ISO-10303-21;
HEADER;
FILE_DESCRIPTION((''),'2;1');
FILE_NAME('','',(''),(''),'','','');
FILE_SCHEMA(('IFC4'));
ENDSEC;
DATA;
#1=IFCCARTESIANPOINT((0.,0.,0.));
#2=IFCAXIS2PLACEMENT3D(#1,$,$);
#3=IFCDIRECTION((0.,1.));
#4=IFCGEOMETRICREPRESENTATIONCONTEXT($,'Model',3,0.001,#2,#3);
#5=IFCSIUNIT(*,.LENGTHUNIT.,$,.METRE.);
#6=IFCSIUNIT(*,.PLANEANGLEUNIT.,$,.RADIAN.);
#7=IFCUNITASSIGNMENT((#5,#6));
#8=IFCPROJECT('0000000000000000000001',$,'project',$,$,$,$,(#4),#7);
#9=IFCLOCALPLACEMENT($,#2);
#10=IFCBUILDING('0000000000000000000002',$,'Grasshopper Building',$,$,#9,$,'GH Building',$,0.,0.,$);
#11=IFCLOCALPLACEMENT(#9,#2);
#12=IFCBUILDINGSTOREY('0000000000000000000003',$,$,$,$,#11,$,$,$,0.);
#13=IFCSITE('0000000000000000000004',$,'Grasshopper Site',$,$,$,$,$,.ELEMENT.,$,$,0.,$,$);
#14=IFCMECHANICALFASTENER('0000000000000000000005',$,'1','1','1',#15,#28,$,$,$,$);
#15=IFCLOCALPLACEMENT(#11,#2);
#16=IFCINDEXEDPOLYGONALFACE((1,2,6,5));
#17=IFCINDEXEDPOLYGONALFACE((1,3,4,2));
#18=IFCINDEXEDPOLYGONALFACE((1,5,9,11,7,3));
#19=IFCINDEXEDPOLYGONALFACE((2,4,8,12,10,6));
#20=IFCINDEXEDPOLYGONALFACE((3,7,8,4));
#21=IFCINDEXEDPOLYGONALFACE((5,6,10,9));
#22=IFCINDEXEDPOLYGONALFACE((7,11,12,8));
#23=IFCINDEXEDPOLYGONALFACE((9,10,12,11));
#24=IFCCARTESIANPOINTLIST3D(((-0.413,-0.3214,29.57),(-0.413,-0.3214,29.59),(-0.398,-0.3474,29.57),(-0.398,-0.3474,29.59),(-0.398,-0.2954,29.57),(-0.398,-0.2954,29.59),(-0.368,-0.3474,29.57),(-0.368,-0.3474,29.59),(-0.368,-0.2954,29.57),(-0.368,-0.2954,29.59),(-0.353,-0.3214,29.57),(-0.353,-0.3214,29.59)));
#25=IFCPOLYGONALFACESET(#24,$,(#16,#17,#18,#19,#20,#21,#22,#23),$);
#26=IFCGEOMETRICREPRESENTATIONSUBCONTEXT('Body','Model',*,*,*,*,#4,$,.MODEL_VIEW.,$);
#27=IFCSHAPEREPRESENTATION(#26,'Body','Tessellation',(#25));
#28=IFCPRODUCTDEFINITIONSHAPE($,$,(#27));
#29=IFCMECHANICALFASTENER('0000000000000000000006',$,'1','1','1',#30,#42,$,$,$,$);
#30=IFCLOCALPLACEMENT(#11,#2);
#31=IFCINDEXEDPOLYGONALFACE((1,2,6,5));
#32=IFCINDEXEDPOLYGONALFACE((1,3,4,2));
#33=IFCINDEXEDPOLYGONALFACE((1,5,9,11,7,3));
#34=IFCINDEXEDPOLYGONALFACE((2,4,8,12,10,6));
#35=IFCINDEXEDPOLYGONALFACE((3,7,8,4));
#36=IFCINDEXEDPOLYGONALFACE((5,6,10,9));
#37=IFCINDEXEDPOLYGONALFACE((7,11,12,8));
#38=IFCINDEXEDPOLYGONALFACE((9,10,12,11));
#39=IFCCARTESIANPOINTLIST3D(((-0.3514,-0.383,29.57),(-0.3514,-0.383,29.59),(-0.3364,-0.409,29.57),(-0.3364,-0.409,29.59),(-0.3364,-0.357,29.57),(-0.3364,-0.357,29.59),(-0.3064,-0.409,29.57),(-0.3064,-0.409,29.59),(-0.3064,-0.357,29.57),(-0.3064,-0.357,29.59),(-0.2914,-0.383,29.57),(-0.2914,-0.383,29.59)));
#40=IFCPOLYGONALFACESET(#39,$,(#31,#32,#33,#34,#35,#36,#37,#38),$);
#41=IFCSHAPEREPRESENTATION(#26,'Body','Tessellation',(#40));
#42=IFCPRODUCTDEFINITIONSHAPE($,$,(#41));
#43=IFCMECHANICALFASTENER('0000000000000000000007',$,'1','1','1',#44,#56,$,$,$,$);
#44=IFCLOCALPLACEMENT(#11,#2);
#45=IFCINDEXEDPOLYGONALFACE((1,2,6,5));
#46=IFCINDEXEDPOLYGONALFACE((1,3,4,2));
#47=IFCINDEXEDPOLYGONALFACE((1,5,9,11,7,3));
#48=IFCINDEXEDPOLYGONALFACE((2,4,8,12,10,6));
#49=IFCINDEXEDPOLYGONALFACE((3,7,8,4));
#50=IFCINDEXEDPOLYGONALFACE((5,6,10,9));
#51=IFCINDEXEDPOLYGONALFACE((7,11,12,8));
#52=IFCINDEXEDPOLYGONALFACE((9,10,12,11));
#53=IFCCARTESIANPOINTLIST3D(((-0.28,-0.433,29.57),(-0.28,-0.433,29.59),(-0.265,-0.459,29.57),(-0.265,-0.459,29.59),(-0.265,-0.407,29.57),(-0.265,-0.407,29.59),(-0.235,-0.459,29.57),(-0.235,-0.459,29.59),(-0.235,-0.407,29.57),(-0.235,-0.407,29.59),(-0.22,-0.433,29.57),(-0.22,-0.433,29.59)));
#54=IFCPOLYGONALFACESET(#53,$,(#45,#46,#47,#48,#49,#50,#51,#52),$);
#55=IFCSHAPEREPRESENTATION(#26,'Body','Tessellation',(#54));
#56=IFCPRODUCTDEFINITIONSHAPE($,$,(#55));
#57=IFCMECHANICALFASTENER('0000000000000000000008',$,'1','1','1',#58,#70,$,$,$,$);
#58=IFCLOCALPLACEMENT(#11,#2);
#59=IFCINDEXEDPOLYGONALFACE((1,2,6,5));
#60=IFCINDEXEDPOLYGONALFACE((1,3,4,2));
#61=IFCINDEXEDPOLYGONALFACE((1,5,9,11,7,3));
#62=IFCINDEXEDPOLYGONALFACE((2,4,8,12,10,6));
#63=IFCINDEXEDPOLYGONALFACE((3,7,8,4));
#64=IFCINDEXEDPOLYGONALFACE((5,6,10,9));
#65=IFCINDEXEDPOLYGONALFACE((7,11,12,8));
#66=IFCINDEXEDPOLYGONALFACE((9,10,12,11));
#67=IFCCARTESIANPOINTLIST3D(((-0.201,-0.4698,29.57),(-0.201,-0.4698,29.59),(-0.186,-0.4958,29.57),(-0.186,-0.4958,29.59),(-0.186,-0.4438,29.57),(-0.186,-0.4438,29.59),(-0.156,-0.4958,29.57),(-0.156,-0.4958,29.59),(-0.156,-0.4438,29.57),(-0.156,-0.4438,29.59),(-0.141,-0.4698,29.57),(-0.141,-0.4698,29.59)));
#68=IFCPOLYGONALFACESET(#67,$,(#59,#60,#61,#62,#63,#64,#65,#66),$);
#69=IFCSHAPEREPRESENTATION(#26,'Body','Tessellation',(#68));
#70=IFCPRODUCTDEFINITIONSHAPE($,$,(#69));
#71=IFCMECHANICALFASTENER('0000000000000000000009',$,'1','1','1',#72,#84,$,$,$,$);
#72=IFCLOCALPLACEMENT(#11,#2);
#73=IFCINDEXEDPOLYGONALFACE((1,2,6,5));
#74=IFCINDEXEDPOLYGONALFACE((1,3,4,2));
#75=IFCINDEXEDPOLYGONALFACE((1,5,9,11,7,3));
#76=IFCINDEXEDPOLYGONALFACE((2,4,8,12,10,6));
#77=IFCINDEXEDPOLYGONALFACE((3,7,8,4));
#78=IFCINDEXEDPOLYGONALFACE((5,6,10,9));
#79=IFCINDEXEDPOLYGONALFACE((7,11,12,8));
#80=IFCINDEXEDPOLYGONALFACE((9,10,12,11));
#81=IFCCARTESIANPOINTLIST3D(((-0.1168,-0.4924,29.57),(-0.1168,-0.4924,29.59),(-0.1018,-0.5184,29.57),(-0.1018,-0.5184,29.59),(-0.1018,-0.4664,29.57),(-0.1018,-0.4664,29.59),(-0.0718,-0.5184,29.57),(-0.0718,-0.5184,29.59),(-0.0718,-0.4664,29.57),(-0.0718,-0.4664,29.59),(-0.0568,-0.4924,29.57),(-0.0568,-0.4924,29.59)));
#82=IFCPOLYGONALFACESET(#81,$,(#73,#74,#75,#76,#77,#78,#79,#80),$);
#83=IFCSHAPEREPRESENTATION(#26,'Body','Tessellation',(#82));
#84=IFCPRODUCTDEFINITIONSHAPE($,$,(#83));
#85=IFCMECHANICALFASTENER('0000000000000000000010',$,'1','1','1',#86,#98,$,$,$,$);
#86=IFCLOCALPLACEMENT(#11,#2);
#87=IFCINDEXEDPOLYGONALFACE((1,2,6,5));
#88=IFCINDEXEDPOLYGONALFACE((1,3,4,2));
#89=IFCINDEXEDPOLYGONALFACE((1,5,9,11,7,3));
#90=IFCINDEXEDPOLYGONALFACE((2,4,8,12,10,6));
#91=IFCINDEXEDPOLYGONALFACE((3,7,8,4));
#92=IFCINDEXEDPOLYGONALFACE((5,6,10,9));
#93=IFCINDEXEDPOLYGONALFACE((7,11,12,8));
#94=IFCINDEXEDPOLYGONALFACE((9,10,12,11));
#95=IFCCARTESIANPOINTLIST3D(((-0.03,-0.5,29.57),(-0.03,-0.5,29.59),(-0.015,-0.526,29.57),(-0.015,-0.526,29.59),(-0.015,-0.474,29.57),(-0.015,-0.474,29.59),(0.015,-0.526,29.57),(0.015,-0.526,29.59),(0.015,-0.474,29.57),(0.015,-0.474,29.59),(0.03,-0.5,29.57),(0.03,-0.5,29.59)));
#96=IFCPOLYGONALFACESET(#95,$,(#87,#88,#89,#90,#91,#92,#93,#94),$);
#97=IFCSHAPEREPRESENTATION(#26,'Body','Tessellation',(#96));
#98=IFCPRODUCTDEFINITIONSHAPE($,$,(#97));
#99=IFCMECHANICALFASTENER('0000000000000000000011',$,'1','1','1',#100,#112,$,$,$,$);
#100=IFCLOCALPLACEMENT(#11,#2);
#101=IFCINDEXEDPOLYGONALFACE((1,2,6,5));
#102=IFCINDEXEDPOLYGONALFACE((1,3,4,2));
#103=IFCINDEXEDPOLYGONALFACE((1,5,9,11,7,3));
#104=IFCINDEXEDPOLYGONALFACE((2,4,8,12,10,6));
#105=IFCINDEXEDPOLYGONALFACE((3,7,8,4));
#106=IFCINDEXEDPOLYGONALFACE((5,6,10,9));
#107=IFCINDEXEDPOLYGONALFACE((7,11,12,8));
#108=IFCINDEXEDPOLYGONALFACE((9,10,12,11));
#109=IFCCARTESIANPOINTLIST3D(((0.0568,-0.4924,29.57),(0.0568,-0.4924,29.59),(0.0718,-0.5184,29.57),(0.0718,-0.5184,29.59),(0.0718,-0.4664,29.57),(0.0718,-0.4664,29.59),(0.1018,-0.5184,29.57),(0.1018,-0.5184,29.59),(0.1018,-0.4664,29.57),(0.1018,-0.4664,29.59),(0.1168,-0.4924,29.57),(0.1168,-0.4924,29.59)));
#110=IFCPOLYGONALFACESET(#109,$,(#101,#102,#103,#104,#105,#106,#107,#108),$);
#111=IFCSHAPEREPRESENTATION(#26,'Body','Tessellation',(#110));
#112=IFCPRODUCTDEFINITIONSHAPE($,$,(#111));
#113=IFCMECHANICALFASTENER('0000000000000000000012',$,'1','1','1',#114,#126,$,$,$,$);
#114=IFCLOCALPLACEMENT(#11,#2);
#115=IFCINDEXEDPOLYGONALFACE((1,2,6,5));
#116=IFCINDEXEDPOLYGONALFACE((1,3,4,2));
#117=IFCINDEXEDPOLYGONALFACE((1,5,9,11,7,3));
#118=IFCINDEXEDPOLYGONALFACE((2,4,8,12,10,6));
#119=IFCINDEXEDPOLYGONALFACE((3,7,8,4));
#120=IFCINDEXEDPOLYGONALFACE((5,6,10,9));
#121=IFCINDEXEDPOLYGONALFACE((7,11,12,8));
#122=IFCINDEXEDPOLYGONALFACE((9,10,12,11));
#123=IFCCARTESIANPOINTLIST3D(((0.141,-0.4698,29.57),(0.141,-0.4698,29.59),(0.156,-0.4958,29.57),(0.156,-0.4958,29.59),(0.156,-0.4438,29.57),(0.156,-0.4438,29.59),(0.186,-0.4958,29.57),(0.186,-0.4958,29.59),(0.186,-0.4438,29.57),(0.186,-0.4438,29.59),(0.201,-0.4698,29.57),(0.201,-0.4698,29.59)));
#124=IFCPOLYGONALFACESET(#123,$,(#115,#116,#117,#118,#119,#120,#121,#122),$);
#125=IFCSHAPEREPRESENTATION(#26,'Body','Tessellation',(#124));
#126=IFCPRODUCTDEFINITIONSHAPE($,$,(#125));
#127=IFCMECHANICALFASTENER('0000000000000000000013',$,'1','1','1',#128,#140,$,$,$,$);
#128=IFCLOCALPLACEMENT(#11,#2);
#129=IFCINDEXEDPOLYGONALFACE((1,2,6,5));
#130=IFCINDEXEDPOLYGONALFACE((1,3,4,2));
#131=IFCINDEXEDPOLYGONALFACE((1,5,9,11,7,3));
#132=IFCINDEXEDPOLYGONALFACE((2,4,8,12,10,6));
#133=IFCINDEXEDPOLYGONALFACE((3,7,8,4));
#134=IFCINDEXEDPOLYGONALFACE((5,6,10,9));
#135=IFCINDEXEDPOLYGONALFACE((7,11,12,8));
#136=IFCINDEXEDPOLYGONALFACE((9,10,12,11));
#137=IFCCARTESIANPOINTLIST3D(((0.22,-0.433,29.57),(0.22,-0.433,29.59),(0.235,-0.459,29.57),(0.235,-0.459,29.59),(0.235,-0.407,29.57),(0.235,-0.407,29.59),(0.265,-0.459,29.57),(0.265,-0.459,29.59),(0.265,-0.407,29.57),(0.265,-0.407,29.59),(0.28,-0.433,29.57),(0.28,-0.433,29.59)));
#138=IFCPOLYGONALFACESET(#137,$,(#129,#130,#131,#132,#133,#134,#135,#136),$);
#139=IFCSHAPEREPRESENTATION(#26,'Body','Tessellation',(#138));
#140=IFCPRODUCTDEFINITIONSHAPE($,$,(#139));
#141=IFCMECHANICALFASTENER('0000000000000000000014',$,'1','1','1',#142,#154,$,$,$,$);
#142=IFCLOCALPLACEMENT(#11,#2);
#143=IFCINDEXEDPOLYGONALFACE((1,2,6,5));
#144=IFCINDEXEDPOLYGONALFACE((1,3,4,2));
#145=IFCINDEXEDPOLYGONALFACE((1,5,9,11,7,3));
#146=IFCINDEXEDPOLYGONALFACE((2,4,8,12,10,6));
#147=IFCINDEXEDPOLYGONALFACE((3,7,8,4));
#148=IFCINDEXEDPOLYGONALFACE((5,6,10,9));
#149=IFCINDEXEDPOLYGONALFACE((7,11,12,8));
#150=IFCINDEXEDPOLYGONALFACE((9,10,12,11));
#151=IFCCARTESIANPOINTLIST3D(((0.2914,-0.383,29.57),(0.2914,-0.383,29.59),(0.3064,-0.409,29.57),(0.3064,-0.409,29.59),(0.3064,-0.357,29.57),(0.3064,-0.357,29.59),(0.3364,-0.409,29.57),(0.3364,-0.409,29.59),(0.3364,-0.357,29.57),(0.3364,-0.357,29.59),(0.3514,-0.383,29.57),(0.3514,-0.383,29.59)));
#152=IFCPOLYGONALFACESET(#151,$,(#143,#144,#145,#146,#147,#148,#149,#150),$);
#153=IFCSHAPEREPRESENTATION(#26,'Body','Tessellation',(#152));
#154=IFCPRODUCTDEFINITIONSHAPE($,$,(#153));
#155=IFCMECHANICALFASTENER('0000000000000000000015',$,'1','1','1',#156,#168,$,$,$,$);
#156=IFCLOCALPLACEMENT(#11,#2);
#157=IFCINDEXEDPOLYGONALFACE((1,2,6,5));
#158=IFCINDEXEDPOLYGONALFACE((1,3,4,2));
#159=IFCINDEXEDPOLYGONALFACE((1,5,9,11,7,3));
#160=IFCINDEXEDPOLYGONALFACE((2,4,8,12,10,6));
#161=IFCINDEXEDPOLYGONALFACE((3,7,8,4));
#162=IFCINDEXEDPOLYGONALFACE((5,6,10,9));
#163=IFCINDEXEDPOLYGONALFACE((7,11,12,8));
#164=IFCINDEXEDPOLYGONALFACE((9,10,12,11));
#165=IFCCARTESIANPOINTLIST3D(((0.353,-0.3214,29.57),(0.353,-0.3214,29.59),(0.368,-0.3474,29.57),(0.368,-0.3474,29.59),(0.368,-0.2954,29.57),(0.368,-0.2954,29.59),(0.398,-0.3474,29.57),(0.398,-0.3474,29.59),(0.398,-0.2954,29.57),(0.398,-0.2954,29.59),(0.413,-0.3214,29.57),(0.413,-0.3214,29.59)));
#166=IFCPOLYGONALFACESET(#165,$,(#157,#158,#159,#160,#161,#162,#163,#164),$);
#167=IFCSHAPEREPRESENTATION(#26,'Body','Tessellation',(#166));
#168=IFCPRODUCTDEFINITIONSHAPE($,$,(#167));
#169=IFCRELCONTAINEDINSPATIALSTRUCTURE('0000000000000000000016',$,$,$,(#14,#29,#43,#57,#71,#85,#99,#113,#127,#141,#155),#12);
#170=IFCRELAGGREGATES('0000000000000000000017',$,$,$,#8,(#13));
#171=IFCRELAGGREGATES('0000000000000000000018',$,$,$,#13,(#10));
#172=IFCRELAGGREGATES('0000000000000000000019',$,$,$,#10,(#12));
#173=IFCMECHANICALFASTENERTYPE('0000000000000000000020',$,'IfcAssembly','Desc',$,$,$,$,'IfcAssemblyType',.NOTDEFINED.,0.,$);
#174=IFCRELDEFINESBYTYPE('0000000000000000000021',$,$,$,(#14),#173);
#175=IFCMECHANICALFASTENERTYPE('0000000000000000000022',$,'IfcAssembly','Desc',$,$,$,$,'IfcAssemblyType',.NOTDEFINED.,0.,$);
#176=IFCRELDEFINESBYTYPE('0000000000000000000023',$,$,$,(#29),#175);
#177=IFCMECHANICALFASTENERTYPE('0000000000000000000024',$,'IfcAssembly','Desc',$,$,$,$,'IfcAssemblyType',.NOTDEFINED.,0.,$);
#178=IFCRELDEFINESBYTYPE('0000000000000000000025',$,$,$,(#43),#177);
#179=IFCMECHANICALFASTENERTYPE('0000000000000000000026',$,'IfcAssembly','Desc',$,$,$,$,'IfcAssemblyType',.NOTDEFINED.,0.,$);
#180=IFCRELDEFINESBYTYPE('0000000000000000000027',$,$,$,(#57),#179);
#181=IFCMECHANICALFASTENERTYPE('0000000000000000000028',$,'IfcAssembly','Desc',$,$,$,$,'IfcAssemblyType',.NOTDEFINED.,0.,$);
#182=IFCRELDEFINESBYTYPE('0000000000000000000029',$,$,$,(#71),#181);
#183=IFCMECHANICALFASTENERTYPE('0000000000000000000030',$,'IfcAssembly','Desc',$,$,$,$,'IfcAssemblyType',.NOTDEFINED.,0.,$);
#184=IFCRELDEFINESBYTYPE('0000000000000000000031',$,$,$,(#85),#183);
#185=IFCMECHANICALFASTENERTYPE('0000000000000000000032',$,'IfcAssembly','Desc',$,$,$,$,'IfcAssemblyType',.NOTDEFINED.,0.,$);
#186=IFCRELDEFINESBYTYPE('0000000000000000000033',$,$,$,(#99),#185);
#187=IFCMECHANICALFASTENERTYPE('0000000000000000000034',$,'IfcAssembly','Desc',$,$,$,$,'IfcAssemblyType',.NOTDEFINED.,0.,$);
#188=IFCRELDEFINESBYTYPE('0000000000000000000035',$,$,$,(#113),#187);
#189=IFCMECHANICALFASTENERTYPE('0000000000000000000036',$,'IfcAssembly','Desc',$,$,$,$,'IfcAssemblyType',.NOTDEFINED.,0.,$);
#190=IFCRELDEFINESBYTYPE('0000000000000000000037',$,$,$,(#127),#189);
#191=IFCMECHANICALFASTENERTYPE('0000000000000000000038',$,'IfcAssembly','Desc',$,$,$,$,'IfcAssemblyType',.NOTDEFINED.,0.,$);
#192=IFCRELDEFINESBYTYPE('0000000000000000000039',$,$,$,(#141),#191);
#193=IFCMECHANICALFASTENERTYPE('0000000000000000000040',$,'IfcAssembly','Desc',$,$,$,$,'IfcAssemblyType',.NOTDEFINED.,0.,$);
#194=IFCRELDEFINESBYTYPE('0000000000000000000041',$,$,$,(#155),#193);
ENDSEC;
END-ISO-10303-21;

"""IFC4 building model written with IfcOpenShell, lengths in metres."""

from ifc_helpers import new_model, si_unit, direction, frame, origin, place, context, subcontext, project, spatial, indexed_curve, outline, extrude, source, transform, mapped, type_object, type_shapes, element, save


model = new_model("IFC4")

# Units and contexts
model_context = context("Model", 3, precision=0.001, world=origin(), true_north=direction((0.0, 1.0)))
body_context = subcontext(model_context, "Body", "Model", "MODEL_VIEW")
ifc_project = project(units=[si_unit("LENGTHUNIT", "METRE"), si_unit("PLANEANGLEUNIT", "RADIAN")], contexts=[model_context])

# Site, building, storey
site = spatial("IfcSite", under=ifc_project, Name="Grasshopper Site", CompositionType="ELEMENT", RefElevation=0.0)
building_placement = place(None, origin())
building = spatial("IfcBuilding", under=site, at=building_placement, Name="Grasshopper Building", LongName="GH Building", ElevationOfRefHeight=0.0, ElevationOfTerrain=0.0)
storey_placement = place(building_placement, origin())
storey = spatial("IfcBuildingStorey", under=building, at=storey_placement, Elevation=0.0)

# Mechanical fasteners
mechanical_fastener_type_1 = type_object("IfcMechanicalFastenerType", Name="IfcAssembly", Description="Desc", ElementType="IfcAssemblyType", NominalDiameter=0.0)
shared_shape_1 = source(origin(), body_context, "Body", "SweptSolid", [
    extrude(outline(indexed_curve([(0.03, 0.0), (0.015, 0.026), (-0.015, 0.026), (-0.03, 0.0), (-0.015, -0.026), (0.015, -0.026), (0.03, 0.0)])), frame((-0.383, -0.3214, 29.57)), (0.0, 0.0, 1.0), 0.02),
])
type_shapes(mechanical_fastener_type_1, [shared_shape_1])
mechanical_fastener_1_placement = place(storey_placement, origin())
element("IfcMechanicalFastener", 1, at=mechanical_fastener_1_placement, inside=storey, type_object=mechanical_fastener_type_1, Name="1", Description="1", ObjectType="1", context=body_context, shape_type="MappedRepresentation", body=[
    mapped(shared_shape_1, transform((0.0, 0.0, 0.0), scale=1.0)),
])
mechanical_fastener_type_2 = type_object("IfcMechanicalFastenerType", Name="IfcAssembly", Description="Desc", ElementType="IfcAssemblyType", NominalDiameter=0.0)
shared_shape_2 = source(origin(), body_context, "Body", "SweptSolid", [
    extrude(outline(indexed_curve([(0.03, 0.0), (0.015, 0.026), (-0.015, 0.026), (-0.03, 0.0), (-0.015, -0.026), (0.015, -0.026), (0.03, 0.0)])), frame((-0.3214, -0.383, 29.57)), (0.0, 0.0, 1.0), 0.02),
])
type_shapes(mechanical_fastener_type_2, [shared_shape_2])
mechanical_fastener_2_placement = place(storey_placement, origin())
element("IfcMechanicalFastener", 2, at=mechanical_fastener_2_placement, inside=storey, type_object=mechanical_fastener_type_2, Name="1", Description="1", ObjectType="1", context=body_context, shape_type="MappedRepresentation", body=[
    mapped(shared_shape_2, transform((0.0, 0.0, 0.0), scale=1.0)),
])
mechanical_fastener_type_3 = type_object("IfcMechanicalFastenerType", Name="IfcAssembly", Description="Desc", ElementType="IfcAssemblyType", NominalDiameter=0.0)
shared_shape_3 = source(origin(), body_context, "Body", "SweptSolid", [
    extrude(outline(indexed_curve([(0.03, 0.0), (0.015, 0.026), (-0.015, 0.026), (-0.03, 0.0), (-0.015, -0.026), (0.015, -0.026), (0.03, 0.0)])), frame((-0.25, -0.433, 29.57)), (0.0, 0.0, 1.0), 0.02),
])
type_shapes(mechanical_fastener_type_3, [shared_shape_3])
mechanical_fastener_3_placement = place(storey_placement, origin())
element("IfcMechanicalFastener", 3, at=mechanical_fastener_3_placement, inside=storey, type_object=mechanical_fastener_type_3, Name="1", Description="1", ObjectType="1", context=body_context, shape_type="MappedRepresentation", body=[
    mapped(shared_shape_3, transform((0.0, 0.0, 0.0), scale=1.0)),
])
mechanical_fastener_type_4 = type_object("IfcMechanicalFastenerType", Name="IfcAssembly", Description="Desc", ElementType="IfcAssemblyType", NominalDiameter=0.0)
shared_shape_4 = source(origin(), body_context, "Body", "SweptSolid", [
    extrude(outline(indexed_curve([(0.03, 0.0), (0.015, 0.026), (-0.015, 0.026), (-0.03, 0.0), (-0.015, -0.026), (0.015, -0.026), (0.03, 0.0)])), frame((-0.171, -0.4698, 29.57)), (0.0, 0.0, 1.0), 0.02),
])
type_shapes(mechanical_fastener_type_4, [shared_shape_4])
mechanical_fastener_4_placement = place(storey_placement, origin())
element("IfcMechanicalFastener", 4, at=mechanical_fastener_4_placement, inside=storey, type_object=mechanical_fastener_type_4, Name="1", Description="1", ObjectType="1", context=body_context, shape_type="MappedRepresentation", body=[
    mapped(shared_shape_4, transform((0.0, 0.0, 0.0), scale=1.0)),
])
mechanical_fastener_type_5 = type_object("IfcMechanicalFastenerType", Name="IfcAssembly", Description="Desc", ElementType="IfcAssemblyType", NominalDiameter=0.0)
shared_shape_5 = source(origin(), body_context, "Body", "SweptSolid", [
    extrude(outline(indexed_curve([(0.03, 0.0), (0.015, 0.026), (-0.015, 0.026), (-0.03, 0.0), (-0.015, -0.026), (0.015, -0.026), (0.03, 0.0)])), frame((-0.0868, -0.4924, 29.57)), (0.0, 0.0, 1.0), 0.02),
])
type_shapes(mechanical_fastener_type_5, [shared_shape_5])
mechanical_fastener_5_placement = place(storey_placement, origin())
element("IfcMechanicalFastener", 5, at=mechanical_fastener_5_placement, inside=storey, type_object=mechanical_fastener_type_5, Name="1", Description="1", ObjectType="1", context=body_context, shape_type="MappedRepresentation", body=[
    mapped(shared_shape_5, transform((0.0, 0.0, 0.0), scale=1.0)),
])
mechanical_fastener_type_6 = type_object("IfcMechanicalFastenerType", Name="IfcAssembly", Description="Desc", ElementType="IfcAssemblyType", NominalDiameter=0.0)
shared_shape_6 = source(origin(), body_context, "Body", "SweptSolid", [
    extrude(outline(indexed_curve([(0.03, 0.0), (0.015, 0.026), (-0.015, 0.026), (-0.03, 0.0), (-0.015, -0.026), (0.015, -0.026), (0.03, 0.0)])), frame((0.0, -0.5, 29.57)), (0.0, 0.0, 1.0), 0.02),
])
type_shapes(mechanical_fastener_type_6, [shared_shape_6])
mechanical_fastener_6_placement = place(storey_placement, origin())
element("IfcMechanicalFastener", 6, at=mechanical_fastener_6_placement, inside=storey, type_object=mechanical_fastener_type_6, Name="1", Description="1", ObjectType="1", context=body_context, shape_type="MappedRepresentation", body=[
    mapped(shared_shape_6, transform((0.0, 0.0, 0.0), scale=1.0)),
])
mechanical_fastener_type_7 = type_object("IfcMechanicalFastenerType", Name="IfcAssembly", Description="Desc", ElementType="IfcAssemblyType", NominalDiameter=0.0)
shared_shape_7 = source(origin(), body_context, "Body", "SweptSolid", [
    extrude(outline(indexed_curve([(0.03, 0.0), (0.015, 0.026), (-0.015, 0.026), (-0.03, 0.0), (-0.015, -0.026), (0.015, -0.026), (0.03, 0.0)])), frame((0.0868, -0.4924, 29.57)), (0.0, 0.0, 1.0), 0.02),
])
type_shapes(mechanical_fastener_type_7, [shared_shape_7])
mechanical_fastener_7_placement = place(storey_placement, origin())
element("IfcMechanicalFastener", 7, at=mechanical_fastener_7_placement, inside=storey, type_object=mechanical_fastener_type_7, Name="1", Description="1", ObjectType="1", context=body_context, shape_type="MappedRepresentation", body=[
    mapped(shared_shape_7, transform((0.0, 0.0, 0.0), scale=1.0)),
])
mechanical_fastener_type_8 = type_object("IfcMechanicalFastenerType", Name="IfcAssembly", Description="Desc", ElementType="IfcAssemblyType", NominalDiameter=0.0)
shared_shape_8 = source(origin(), body_context, "Body", "SweptSolid", [
    extrude(outline(indexed_curve([(0.03, 0.0), (0.015, 0.026), (-0.015, 0.026), (-0.03, 0.0), (-0.015, -0.026), (0.015, -0.026), (0.03, 0.0)])), frame((0.171, -0.4698, 29.57)), (0.0, 0.0, 1.0), 0.02),
])
type_shapes(mechanical_fastener_type_8, [shared_shape_8])
mechanical_fastener_8_placement = place(storey_placement, origin())
element("IfcMechanicalFastener", 8, at=mechanical_fastener_8_placement, inside=storey, type_object=mechanical_fastener_type_8, Name="1", Description="1", ObjectType="1", context=body_context, shape_type="MappedRepresentation", body=[
    mapped(shared_shape_8, transform((0.0, 0.0, 0.0), scale=1.0)),
])
mechanical_fastener_type_9 = type_object("IfcMechanicalFastenerType", Name="IfcAssembly", Description="Desc", ElementType="IfcAssemblyType", NominalDiameter=0.0)
shared_shape_9 = source(origin(), body_context, "Body", "SweptSolid", [
    extrude(outline(indexed_curve([(0.03, 0.0), (0.015, 0.026), (-0.015, 0.026), (-0.03, 0.0), (-0.015, -0.026), (0.015, -0.026), (0.03, 0.0)])), frame((0.25, -0.433, 29.57)), (0.0, 0.0, 1.0), 0.02),
])
type_shapes(mechanical_fastener_type_9, [shared_shape_9])
mechanical_fastener_9_placement = place(storey_placement, origin())
element("IfcMechanicalFastener", 9, at=mechanical_fastener_9_placement, inside=storey, type_object=mechanical_fastener_type_9, Name="1", Description="1", ObjectType="1", context=body_context, shape_type="MappedRepresentation", body=[
    mapped(shared_shape_9, transform((0.0, 0.0, 0.0), scale=1.0)),
])
mechanical_fastener_type_10 = type_object("IfcMechanicalFastenerType", Name="IfcAssembly", Description="Desc", ElementType="IfcAssemblyType", NominalDiameter=0.0)
shared_shape_10 = source(origin(), body_context, "Body", "SweptSolid", [
    extrude(outline(indexed_curve([(0.03, 0.0), (0.015, 0.026), (-0.015, 0.026), (-0.03, 0.0), (-0.015, -0.026), (0.015, -0.026), (0.03, 0.0)])), frame((0.3214, -0.383, 29.57)), (0.0, 0.0, 1.0), 0.02),
])
type_shapes(mechanical_fastener_type_10, [shared_shape_10])
mechanical_fastener_10_placement = place(storey_placement, origin())
element("IfcMechanicalFastener", 10, at=mechanical_fastener_10_placement, inside=storey, type_object=mechanical_fastener_type_10, Name="1", Description="1", ObjectType="1", context=body_context, shape_type="MappedRepresentation", body=[
    mapped(shared_shape_10, transform((0.0, 0.0, 0.0), scale=1.0)),
])
mechanical_fastener_type_11 = type_object("IfcMechanicalFastenerType", Name="IfcAssembly", Description="Desc", ElementType="IfcAssemblyType", NominalDiameter=0.0)
shared_shape_11 = source(origin(), body_context, "Body", "SweptSolid", [
    extrude(outline(indexed_curve([(0.03, 0.0), (0.015, 0.026), (-0.015, 0.026), (-0.03, 0.0), (-0.015, -0.026), (0.015, -0.026), (0.03, 0.0)])), frame((0.383, -0.3214, 29.57)), (0.0, 0.0, 1.0), 0.02),
])
type_shapes(mechanical_fastener_type_11, [shared_shape_11])
mechanical_fastener_11_placement = place(storey_placement, origin())
element("IfcMechanicalFastener", 11, at=mechanical_fastener_11_placement, inside=storey, type_object=mechanical_fastener_type_11, Name="1", Description="1", ObjectType="1", context=body_context, shape_type="MappedRepresentation", body=[
    mapped(shared_shape_11, transform((0.0, 0.0, 0.0), scale=1.0)),
])

save(model, "model.ifc")
